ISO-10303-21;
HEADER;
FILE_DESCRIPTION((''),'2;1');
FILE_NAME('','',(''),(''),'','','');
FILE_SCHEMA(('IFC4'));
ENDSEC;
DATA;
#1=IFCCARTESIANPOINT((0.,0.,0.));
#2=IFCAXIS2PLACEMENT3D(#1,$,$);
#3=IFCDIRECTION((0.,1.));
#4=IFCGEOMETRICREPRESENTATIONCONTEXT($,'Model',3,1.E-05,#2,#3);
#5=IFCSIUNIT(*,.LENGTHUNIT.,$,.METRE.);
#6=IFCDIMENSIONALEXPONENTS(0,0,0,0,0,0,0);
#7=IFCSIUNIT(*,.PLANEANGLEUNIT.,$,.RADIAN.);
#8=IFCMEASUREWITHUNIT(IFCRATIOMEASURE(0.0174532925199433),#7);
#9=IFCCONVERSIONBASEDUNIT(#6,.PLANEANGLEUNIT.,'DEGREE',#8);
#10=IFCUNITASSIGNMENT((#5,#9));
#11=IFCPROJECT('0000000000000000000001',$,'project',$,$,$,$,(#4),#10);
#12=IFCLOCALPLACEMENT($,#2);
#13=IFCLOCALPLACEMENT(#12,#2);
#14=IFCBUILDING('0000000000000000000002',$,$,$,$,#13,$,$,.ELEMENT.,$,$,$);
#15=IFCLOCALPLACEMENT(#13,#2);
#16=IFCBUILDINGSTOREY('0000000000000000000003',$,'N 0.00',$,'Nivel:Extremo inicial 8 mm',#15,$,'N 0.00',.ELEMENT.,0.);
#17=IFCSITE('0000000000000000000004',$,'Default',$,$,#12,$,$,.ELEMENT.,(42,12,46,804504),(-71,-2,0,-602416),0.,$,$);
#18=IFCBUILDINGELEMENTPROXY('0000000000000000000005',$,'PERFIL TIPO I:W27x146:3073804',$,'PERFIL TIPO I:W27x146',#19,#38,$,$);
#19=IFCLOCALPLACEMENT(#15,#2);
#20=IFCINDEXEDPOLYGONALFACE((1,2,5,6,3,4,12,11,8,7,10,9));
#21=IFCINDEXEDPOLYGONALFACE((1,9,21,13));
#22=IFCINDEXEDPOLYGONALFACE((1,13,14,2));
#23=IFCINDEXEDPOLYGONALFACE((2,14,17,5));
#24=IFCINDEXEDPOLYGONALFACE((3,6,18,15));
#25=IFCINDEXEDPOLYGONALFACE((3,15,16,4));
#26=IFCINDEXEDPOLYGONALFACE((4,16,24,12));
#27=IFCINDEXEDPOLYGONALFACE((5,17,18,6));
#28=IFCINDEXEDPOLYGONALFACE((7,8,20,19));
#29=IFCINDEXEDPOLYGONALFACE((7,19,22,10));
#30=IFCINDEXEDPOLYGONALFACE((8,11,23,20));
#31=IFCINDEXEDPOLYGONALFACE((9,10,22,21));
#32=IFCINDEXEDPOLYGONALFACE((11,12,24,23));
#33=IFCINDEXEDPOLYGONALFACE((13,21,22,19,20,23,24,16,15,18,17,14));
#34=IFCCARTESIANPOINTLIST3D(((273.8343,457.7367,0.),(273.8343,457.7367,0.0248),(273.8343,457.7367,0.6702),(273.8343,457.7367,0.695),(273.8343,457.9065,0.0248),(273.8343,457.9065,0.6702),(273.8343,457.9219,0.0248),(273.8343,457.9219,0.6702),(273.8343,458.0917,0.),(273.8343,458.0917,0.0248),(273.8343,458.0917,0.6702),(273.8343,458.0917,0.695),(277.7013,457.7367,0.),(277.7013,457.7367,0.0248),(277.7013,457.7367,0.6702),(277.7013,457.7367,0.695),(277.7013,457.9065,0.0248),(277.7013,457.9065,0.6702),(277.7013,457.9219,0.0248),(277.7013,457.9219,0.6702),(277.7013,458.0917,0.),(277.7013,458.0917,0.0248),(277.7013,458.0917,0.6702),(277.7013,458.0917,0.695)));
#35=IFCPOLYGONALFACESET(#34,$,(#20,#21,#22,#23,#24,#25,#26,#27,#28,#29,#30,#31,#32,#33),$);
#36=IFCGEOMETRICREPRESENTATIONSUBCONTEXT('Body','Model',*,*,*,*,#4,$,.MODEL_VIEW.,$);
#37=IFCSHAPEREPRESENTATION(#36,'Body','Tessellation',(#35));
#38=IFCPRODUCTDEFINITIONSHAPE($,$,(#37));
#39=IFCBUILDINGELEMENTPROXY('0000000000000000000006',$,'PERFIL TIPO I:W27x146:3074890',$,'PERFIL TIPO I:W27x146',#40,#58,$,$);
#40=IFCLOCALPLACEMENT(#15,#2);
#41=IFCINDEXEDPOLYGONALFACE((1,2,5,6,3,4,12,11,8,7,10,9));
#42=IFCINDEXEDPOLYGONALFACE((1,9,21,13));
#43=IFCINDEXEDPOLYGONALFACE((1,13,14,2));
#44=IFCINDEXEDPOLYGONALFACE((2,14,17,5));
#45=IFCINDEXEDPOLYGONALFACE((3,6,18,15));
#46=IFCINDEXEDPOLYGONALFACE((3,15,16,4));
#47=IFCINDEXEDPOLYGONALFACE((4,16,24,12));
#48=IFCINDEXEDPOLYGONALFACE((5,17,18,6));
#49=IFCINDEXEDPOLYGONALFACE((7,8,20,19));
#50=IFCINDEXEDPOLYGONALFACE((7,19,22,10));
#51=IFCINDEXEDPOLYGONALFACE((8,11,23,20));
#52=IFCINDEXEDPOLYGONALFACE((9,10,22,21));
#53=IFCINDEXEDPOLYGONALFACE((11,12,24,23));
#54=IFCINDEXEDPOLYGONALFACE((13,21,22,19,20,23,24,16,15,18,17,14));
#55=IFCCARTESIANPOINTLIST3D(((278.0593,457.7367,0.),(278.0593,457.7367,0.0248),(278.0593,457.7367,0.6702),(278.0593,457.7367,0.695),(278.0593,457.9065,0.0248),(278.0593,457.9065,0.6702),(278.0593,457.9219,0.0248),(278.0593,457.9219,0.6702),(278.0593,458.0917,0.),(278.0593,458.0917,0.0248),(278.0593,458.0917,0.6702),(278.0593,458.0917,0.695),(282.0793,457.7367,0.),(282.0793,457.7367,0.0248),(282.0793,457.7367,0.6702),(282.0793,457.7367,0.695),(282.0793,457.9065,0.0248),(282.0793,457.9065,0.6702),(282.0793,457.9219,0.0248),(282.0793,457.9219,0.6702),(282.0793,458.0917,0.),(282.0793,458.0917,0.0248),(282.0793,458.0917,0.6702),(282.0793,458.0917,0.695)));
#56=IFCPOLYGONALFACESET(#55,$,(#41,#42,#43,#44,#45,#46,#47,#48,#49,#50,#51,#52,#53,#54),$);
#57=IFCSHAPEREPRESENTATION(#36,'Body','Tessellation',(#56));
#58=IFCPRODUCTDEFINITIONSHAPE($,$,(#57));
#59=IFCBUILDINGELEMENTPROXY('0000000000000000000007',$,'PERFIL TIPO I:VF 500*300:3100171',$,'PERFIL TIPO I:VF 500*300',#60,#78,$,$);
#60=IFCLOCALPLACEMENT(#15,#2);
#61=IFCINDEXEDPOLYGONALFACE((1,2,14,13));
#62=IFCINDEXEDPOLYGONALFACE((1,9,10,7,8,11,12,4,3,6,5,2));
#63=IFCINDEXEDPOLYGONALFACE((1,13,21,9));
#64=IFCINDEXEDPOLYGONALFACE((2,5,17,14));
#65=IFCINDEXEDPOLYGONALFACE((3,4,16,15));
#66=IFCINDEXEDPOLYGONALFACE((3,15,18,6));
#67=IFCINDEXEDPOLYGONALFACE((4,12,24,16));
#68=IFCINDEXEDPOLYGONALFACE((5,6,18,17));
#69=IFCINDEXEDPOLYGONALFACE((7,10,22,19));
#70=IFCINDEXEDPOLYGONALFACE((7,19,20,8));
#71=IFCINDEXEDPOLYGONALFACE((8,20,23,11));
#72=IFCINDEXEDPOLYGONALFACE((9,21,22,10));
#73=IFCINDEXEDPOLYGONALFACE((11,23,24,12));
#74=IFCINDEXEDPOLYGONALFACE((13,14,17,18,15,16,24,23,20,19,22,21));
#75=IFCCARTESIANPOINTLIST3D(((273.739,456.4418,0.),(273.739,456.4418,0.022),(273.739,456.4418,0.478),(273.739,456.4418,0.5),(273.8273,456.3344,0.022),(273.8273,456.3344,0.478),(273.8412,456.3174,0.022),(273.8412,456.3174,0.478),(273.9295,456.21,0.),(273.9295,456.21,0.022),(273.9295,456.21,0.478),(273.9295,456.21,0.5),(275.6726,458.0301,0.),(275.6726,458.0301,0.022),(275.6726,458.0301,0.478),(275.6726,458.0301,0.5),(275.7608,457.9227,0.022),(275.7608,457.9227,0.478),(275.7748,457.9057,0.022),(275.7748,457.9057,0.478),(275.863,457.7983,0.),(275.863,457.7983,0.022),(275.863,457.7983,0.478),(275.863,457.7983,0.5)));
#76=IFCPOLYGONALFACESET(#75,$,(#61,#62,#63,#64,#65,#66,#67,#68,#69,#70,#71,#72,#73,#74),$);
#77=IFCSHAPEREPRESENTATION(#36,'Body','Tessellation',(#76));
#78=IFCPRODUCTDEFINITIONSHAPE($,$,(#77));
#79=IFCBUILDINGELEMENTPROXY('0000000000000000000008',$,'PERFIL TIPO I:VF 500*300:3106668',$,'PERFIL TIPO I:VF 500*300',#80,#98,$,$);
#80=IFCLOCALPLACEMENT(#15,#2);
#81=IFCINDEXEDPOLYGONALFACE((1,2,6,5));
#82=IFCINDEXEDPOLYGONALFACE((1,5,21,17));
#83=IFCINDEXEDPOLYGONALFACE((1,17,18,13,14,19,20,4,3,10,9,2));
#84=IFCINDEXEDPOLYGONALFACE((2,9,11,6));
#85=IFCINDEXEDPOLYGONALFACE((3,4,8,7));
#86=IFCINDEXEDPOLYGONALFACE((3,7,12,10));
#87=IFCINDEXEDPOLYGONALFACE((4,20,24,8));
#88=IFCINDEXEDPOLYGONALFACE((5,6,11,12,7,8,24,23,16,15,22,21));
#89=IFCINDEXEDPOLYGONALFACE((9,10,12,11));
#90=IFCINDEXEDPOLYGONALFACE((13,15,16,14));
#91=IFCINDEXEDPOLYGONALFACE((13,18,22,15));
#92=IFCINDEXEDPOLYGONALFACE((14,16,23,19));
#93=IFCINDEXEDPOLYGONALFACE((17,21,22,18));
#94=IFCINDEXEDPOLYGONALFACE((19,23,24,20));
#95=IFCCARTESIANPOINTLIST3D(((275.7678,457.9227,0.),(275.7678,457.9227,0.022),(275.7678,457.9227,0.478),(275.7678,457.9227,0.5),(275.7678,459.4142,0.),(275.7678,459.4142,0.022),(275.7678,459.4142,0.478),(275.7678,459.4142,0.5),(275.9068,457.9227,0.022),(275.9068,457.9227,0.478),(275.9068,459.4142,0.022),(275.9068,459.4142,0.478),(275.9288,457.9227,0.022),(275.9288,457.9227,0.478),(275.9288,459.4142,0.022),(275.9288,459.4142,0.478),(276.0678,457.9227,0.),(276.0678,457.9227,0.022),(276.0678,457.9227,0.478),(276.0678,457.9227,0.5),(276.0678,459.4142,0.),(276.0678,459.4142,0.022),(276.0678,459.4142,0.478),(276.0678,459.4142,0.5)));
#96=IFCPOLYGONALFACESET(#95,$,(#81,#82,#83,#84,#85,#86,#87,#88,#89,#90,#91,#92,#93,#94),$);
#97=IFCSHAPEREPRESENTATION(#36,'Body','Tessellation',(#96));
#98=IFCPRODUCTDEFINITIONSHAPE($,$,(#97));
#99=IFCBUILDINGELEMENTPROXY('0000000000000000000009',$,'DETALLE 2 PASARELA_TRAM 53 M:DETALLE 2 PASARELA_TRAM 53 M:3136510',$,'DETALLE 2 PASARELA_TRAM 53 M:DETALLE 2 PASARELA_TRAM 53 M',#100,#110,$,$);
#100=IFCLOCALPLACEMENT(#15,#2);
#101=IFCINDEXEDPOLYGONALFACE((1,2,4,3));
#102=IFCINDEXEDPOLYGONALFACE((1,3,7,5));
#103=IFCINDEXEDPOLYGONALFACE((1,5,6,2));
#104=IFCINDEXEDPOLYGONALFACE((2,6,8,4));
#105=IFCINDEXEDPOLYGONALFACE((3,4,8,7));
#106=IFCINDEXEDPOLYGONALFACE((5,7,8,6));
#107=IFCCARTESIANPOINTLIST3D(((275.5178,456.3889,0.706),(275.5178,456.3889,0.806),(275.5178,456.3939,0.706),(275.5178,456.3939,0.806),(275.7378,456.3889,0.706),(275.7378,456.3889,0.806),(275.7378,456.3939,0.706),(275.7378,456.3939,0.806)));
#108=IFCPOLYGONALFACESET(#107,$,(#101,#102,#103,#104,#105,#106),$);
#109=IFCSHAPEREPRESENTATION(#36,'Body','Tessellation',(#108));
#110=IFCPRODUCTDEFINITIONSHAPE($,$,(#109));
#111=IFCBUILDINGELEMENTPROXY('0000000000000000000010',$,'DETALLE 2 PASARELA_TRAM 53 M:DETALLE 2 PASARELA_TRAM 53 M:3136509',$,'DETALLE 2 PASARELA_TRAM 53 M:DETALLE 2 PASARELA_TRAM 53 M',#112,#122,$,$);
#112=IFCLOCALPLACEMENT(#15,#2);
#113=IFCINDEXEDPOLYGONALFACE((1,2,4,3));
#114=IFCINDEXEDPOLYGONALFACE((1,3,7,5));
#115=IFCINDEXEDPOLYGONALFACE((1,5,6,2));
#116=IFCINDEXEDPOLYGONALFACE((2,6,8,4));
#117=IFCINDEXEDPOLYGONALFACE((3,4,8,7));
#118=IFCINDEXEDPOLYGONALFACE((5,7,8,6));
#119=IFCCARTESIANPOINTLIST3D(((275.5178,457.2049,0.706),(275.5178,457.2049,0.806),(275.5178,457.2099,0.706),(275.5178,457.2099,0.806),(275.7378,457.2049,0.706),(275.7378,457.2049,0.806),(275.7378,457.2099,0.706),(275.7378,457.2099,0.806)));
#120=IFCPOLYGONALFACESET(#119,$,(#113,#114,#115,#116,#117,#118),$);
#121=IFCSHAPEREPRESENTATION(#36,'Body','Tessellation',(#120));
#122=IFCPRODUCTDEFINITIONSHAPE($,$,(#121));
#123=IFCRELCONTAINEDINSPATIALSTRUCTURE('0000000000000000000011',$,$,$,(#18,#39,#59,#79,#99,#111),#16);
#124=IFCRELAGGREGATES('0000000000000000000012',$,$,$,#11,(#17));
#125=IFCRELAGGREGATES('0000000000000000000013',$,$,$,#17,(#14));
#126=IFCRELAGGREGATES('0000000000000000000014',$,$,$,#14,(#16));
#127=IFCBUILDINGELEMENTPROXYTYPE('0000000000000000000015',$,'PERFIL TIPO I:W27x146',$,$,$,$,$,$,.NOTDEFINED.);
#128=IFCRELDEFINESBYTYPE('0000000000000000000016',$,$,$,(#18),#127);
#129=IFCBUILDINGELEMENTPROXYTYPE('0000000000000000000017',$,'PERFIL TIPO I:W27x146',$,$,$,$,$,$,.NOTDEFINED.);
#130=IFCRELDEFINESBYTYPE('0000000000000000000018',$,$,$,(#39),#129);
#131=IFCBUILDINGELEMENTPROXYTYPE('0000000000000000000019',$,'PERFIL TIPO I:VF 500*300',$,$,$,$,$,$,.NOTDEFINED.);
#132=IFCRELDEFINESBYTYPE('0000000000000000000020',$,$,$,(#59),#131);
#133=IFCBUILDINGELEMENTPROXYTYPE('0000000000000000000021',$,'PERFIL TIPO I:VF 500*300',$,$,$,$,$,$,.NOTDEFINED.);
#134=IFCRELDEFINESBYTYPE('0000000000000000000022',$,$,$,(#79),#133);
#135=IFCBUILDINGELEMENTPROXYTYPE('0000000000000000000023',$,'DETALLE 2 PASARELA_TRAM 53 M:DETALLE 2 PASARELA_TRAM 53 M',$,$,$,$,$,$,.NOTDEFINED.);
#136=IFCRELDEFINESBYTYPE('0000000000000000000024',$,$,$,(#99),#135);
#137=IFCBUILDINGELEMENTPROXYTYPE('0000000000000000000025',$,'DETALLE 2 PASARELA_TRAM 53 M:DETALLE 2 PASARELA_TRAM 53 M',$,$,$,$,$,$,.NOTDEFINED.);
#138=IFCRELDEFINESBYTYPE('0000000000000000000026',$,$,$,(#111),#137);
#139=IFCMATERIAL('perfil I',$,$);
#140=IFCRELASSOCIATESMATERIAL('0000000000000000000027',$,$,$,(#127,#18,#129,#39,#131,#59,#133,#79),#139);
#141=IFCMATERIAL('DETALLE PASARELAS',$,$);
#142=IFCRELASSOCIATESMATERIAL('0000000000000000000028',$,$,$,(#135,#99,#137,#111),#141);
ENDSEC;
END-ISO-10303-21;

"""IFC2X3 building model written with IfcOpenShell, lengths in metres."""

from ifc_helpers import new_model, entity, si_unit, converted_unit, direction, frame, frame_2d, origin, place, context, subcontext, project, spatial, polyline, rectangle, outline, extrude, source, transform, mapped, material, type_object, type_shapes, element, save


model = new_model("IFC2X3")

# Units and contexts
model_context = context("Model", 3, precision=1e-05, world=origin(), true_north=direction((0.0, 1.0)))
body_context = subcontext(model_context, "Body", "Model", "MODEL_VIEW")
ifc_project = project(units=[si_unit("LENGTHUNIT", "METRE"), converted_unit("PLANEANGLEUNIT", "DEGREE", entity("IfcRatioMeasure", 0.0174532925199433), si_unit("PLANEANGLEUNIT", "RADIAN"), dimensions=[0, 0, 0, 0, 0, 0, 0])], contexts=[model_context])

# Site, building, storey
site_placement = place(None, origin())
site = spatial("IfcSite", under=ifc_project, at=site_placement, Name="Default", CompositionType="ELEMENT", RefLatitude=(42, 12, 46, 804504), RefLongitude=(-71, -2, 0, -602416), RefElevation=0.0)
building_placement = place(site_placement, origin())
building = spatial("IfcBuilding", under=site, at=building_placement, CompositionType="ELEMENT")
storey_placement = place(building_placement, origin())
storey = spatial("IfcBuildingStorey", under=building, at=storey_placement, Name="N 0.00", ObjectType="Nivel:Extremo inicial 8 mm", LongName="N 0.00", CompositionType="ELEMENT", Elevation=0.0)

# Building element proxies
ifc_material_1 = material(Name="perfil I")
building_element_proxy_type_1 = type_object("IfcBuildingElementProxyType", Name="PERFIL TIPO I:W27x146", PredefinedType="NOTDEFINED", material=ifc_material_1)
shared_shape_1 = source(origin(), body_context, "Body", "SweptSolid", [
    extrude(outline(polyline([(0.3227, -0.1775), (0.3475, -0.1775), (0.3475, 0.1775), (0.3227, 0.1775), (0.3227, 0.0077), (-0.3227, 0.0077), (-0.3227, 0.1775), (-0.3475, 0.1775), (-0.3475, -0.1775), (-0.3227, -0.1775), (-0.3227, -0.0077), (0.3227, -0.0077), (0.3227, -0.1775)])), frame((0.0, 0.0, 0.3475), z_axis=(1.0, 0.0, 0.0), x_axis=(0.0, 0.0, 1.0)), (0.0, 0.0, 1.0), 3.867),
])
type_shapes(building_element_proxy_type_1, [shared_shape_1])
proxy_1_placement = place(storey_placement, frame((273.8343, 457.9142, 0.0)))
element("IfcBuildingElementProxy", 1, at=proxy_1_placement, inside=storey, type_object=building_element_proxy_type_1, material=ifc_material_1, Name="PERFIL TIPO I:W27x146:3073804", ObjectType="PERFIL TIPO I:W27x146", context=body_context, shape_type="MappedRepresentation", body=[
    mapped(shared_shape_1, transform((0.0, 0.0, 0.0), scale=1.0)),
])
building_element_proxy_type_2 = type_object("IfcBuildingElementProxyType", Name="PERFIL TIPO I:W27x146", PredefinedType="NOTDEFINED", material=ifc_material_1)
shared_shape_2 = source(origin(), body_context, "Body", "SweptSolid", [
    extrude(outline(polyline([(0.3227, -0.1775), (0.3475, -0.1775), (0.3475, 0.1775), (0.3227, 0.1775), (0.3227, 0.0077), (-0.3227, 0.0077), (-0.3227, 0.1775), (-0.3475, 0.1775), (-0.3475, -0.1775), (-0.3227, -0.1775), (-0.3227, -0.0077), (0.3227, -0.0077), (0.3227, -0.1775)])), frame((0.0, 0.0, 0.3475), z_axis=(1.0, 0.0, 0.0), x_axis=(0.0, 0.0, 1.0)), (0.0, 0.0, 1.0), 4.02),
])
type_shapes(building_element_proxy_type_2, [shared_shape_2])
proxy_2_placement = place(storey_placement, frame((278.0593, 457.9142, 0.0)))
element("IfcBuildingElementProxy", 2, at=proxy_2_placement, inside=storey, type_object=building_element_proxy_type_2, material=ifc_material_1, Name="PERFIL TIPO I:W27x146:3074890", ObjectType="PERFIL TIPO I:W27x146", context=body_context, shape_type="MappedRepresentation", body=[
    mapped(shared_shape_2, transform((0.0, 0.0, 0.0), scale=1.0)),
])
building_element_proxy_type_3 = type_object("IfcBuildingElementProxyType", Name="PERFIL TIPO I:VF 500*300", PredefinedType="NOTDEFINED", material=ifc_material_1)
shared_shape_3 = source(origin(), body_context, "Body", "SweptSolid", [
    extrude(outline(polyline([(0.228, -0.15), (0.25, -0.15), (0.25, 0.15), (0.228, 0.15), (0.228, 0.011), (-0.228, 0.011), (-0.228, 0.15), (-0.25, 0.15), (-0.25, -0.15), (-0.228, -0.15), (-0.228, -0.011), (0.228, -0.011), (0.228, -0.15)])), frame((0.0, 0.0, 0.25), z_axis=(1.0, 0.0, 0.0), x_axis=(0.0, 0.0, 1.0)), (0.0, 0.0, 1.0), 2.5022),
])
type_shapes(building_element_proxy_type_3, [shared_shape_3])
proxy_3_placement = place(storey_placement, frame((275.7678, 457.9142, 0.0), z_axis=(0.0, 0.0, 1.0), x_axis=(-0.772718, -0.63475, 0.0)))
element("IfcBuildingElementProxy", 3, at=proxy_3_placement, inside=storey, type_object=building_element_proxy_type_3, material=ifc_material_1, Name="PERFIL TIPO I:VF 500*300:3100171", ObjectType="PERFIL TIPO I:VF 500*300", context=body_context, shape_type="MappedRepresentation", body=[
    mapped(shared_shape_3, transform((0.0, 0.0, 0.0), scale=1.0)),
])
building_element_proxy_type_4 = type_object("IfcBuildingElementProxyType", Name="PERFIL TIPO I:VF 500*300", PredefinedType="NOTDEFINED", material=ifc_material_1)
shared_shape_4 = source(origin(), body_context, "Body", "SweptSolid", [
    extrude(outline(polyline([(0.228, -0.15), (0.25, -0.15), (0.25, 0.15), (0.228, 0.15), (0.228, 0.011), (-0.228, 0.011), (-0.228, 0.15), (-0.25, 0.15), (-0.25, -0.15), (-0.228, -0.15), (-0.228, -0.011), (0.228, -0.011), (0.228, -0.15)])), frame((0.0, 0.0, 0.25), z_axis=(1.0, 0.0, 0.0), x_axis=(0.0, 0.0, 1.0)), (0.0, 0.0, 1.0), 1.4915),
])
type_shapes(building_element_proxy_type_4, [shared_shape_4])
proxy_4_placement = place(storey_placement, frame((275.9178, 457.9227, 0.0), z_axis=(0.0, 0.0, 1.0), x_axis=(0.0, 1.0, 0.0)))
element("IfcBuildingElementProxy", 4, at=proxy_4_placement, inside=storey, type_object=building_element_proxy_type_4, material=ifc_material_1, Name="PERFIL TIPO I:VF 500*300:3106668", ObjectType="PERFIL TIPO I:VF 500*300", context=body_context, shape_type="MappedRepresentation", body=[
    mapped(shared_shape_4, transform((0.0, 0.0, 0.0), scale=1.0)),
])
ifc_material_2 = material(Name="DETALLE PASARELAS")
building_element_proxy_type_5 = type_object("IfcBuildingElementProxyType", Name="DETALLE 2 PASARELA_TRAM 53 M:DETALLE 2 PASARELA_TRAM 53 M", PredefinedType="NOTDEFINED", material=ifc_material_2)
shared_shape_5 = source(origin(), body_context, "Body", "SweptSolid", [
    extrude(rectangle(XDim=0.22, YDim=0.005, at=frame_2d((0.0, 0.0), x_axis=(1.0, 0.0))), frame((0.11, 0.0475, 0.0), z_axis=(0.0, 0.0, 1.0), x_axis=(-1.0, 0.0, 0.0)), (0.0, 0.0, 1.0), 0.1),
])
type_shapes(building_element_proxy_type_5, [shared_shape_5])
proxy_5_placement = place(storey_placement, frame((275.5178, 456.3439, 0.706)))
element("IfcBuildingElementProxy", 5, at=proxy_5_placement, inside=storey, type_object=building_element_proxy_type_5, material=ifc_material_2, Name="DETALLE 2 PASARELA_TRAM 53 M:DETALLE 2 PASARELA_TRAM 53 M:3136510", ObjectType="DETALLE 2 PASARELA_TRAM 53 M:DETALLE 2 PASARELA_TRAM 53 M", context=body_context, shape_type="MappedRepresentation", body=[
    mapped(shared_shape_5, transform((0.0, 0.0, 0.0), scale=1.0)),
])
building_element_proxy_type_6 = type_object("IfcBuildingElementProxyType", Name="DETALLE 2 PASARELA_TRAM 53 M:DETALLE 2 PASARELA_TRAM 53 M", PredefinedType="NOTDEFINED", material=ifc_material_2)
shared_shape_6 = source(origin(), body_context, "Body", "SweptSolid", [
    extrude(rectangle(XDim=0.005, YDim=0.22, at=frame_2d((0.0, 0.0), x_axis=(1.0, 0.0))), frame((0.11, -0.0475, 0.0), z_axis=(0.0, 0.0, 1.0), x_axis=(0.0, 1.0, 0.0)), (0.0, 0.0, 1.0), 0.1),
])
type_shapes(building_element_proxy_type_6, [shared_shape_6])
proxy_6_placement = place(storey_placement, frame((275.5178, 457.2549, 0.706)))
element("IfcBuildingElementProxy", 6, at=proxy_6_placement, inside=storey, type_object=building_element_proxy_type_6, material=ifc_material_2, Name="DETALLE 2 PASARELA_TRAM 53 M:DETALLE 2 PASARELA_TRAM 53 M:3136509", ObjectType="DETALLE 2 PASARELA_TRAM 53 M:DETALLE 2 PASARELA_TRAM 53 M", context=body_context, shape_type="MappedRepresentation", body=[
    mapped(shared_shape_6, transform((0.0, 0.0, 0.0), scale=1.0)),
])

save(model, "model.ifc")
